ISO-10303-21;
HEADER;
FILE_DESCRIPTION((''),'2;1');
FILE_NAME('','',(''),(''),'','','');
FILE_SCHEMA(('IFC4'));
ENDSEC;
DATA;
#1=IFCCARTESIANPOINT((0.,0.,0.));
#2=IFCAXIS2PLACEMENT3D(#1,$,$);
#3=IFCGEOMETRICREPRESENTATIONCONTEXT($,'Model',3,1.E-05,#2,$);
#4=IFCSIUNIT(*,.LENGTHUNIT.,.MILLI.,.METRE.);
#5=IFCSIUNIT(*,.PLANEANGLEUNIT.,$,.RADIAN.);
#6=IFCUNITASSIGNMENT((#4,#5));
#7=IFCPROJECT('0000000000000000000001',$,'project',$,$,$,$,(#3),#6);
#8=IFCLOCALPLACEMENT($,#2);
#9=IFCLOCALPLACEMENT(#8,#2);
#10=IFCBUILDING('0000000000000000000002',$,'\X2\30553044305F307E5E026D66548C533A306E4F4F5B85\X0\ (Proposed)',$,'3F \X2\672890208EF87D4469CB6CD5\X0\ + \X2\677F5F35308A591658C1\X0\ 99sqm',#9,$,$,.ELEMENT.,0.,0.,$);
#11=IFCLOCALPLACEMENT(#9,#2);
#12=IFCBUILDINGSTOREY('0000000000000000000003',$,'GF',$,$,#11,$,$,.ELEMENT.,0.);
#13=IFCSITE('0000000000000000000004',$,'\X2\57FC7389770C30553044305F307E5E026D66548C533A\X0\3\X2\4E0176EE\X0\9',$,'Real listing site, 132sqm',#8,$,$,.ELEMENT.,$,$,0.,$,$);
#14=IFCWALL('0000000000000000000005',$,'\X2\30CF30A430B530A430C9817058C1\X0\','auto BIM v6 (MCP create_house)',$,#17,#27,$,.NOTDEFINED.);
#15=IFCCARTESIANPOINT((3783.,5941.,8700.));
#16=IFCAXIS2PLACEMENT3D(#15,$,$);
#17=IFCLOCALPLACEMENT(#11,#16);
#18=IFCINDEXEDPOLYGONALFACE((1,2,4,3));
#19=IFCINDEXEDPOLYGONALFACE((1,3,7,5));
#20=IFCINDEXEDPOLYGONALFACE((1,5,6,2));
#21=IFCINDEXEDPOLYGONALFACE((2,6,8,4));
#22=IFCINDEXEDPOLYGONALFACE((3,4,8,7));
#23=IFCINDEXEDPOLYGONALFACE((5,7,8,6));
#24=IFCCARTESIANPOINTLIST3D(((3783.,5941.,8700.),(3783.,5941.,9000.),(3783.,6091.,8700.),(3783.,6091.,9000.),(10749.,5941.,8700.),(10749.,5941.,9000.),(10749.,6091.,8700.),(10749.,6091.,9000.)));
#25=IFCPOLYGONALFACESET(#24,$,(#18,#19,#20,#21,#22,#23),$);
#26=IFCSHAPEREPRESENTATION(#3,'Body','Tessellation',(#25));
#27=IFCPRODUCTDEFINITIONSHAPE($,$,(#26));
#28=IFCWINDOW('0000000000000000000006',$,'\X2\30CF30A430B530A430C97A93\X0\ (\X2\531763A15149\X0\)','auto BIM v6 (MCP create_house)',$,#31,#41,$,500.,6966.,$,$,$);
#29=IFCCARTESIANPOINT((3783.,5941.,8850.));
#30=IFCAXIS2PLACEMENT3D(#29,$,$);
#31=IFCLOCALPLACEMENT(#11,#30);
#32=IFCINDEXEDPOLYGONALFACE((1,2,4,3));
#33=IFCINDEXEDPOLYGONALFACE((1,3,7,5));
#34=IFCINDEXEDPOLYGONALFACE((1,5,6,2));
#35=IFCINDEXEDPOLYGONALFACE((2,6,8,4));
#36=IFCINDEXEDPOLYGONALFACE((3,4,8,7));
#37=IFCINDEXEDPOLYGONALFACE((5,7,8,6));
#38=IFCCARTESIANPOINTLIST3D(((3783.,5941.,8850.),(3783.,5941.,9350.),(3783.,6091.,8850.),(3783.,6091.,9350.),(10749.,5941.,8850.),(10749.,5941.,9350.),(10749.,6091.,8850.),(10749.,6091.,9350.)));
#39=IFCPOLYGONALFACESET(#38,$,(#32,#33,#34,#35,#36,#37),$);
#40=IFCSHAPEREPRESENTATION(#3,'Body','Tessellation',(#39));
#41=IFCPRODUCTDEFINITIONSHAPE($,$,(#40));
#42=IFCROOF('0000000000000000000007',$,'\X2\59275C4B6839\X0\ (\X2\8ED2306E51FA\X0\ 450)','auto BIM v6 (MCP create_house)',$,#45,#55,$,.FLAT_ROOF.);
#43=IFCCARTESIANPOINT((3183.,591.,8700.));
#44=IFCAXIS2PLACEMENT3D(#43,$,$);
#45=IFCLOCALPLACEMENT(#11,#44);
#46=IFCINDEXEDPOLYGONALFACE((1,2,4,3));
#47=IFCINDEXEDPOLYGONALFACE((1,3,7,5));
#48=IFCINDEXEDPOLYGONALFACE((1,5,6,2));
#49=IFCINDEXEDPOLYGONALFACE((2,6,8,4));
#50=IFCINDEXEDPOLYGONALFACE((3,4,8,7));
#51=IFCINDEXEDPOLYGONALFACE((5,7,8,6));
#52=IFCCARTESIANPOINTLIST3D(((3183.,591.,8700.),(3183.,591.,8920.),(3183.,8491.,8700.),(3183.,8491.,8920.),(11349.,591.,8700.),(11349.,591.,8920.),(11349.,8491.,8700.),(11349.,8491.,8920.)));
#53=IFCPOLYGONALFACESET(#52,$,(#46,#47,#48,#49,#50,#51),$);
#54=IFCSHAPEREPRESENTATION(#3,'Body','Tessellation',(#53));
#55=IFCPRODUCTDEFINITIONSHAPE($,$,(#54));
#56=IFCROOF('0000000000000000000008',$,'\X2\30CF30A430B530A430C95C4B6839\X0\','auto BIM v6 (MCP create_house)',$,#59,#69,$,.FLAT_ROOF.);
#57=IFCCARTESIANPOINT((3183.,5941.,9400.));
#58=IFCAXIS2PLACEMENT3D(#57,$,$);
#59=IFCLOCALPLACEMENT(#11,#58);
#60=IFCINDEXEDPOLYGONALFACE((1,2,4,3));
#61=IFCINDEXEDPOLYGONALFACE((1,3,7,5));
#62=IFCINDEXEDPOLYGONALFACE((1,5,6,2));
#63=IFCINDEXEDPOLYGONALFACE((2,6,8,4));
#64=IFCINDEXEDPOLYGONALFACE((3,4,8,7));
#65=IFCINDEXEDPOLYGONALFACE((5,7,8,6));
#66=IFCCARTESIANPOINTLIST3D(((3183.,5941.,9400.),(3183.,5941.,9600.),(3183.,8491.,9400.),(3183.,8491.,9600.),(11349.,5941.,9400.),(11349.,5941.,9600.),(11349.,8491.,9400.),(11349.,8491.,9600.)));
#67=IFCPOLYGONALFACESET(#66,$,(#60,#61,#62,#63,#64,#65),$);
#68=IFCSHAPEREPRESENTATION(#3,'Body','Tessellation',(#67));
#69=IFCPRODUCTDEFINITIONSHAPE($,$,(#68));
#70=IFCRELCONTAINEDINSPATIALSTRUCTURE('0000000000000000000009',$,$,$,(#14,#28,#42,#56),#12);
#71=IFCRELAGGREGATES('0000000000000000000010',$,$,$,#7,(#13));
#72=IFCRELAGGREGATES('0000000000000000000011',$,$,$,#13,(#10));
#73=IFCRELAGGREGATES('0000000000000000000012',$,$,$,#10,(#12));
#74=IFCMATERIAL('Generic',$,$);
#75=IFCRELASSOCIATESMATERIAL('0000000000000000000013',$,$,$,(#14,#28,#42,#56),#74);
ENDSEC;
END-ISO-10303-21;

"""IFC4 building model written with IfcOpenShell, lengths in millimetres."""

from ifc_helpers import new_model, si_unit, frame, frame_2d, origin, place, context, project, spatial, rectangle, extrude, material, element, fill, save


model = new_model("IFC4")

# Units and contexts
model_context = context("Model", 3, precision=1e-05, world=origin())
ifc_project = project(units=[si_unit("LENGTHUNIT", "METRE", prefix="MILLI"), si_unit("PLANEANGLEUNIT", "RADIAN")], contexts=[model_context])

# Site, building, storey
site_placement = place(None, origin())
site = spatial("IfcSite", under=ifc_project, at=site_placement, Name="埼玉県さいたま市浦和区3丁目9", ObjectType="Real listing site, 132sqm", CompositionType="ELEMENT", RefElevation=0.0)
building_placement = place(site_placement, origin())
building = spatial("IfcBuilding", under=site, at=building_placement, Name="さいたま市浦和区の住宅 (Proposed)", ObjectType="3F 木造軸組構法 + 板張り外壁 99sqm", CompositionType="ELEMENT", ElevationOfRefHeight=0.0, ElevationOfTerrain=0.0)
storey_placement = place(building_placement, origin())
storey = spatial("IfcBuildingStorey", under=building, at=storey_placement, Name="GF", CompositionType="ELEMENT", Elevation=0.0)

# Shared definitions
ifc_material = material(Name="Generic")

# Wall, opening, window
wall_1_placement = place(storey_placement, frame((3783.0, 5941.0, 8700.0)))
wall_1 = element("IfcWall", 1, at=wall_1_placement, inside=storey, material=ifc_material, Name="ハイサイド腰壁", Description="auto BIM v6 (MCP create_house)", PredefinedType="NOTDEFINED", context=model_context, shape_type="SweptSolid", body=[
    extrude(rectangle(XDim=6966.0, YDim=150.0, at=frame_2d((3483.0, 75.0))), frame((3783.0, 5941.0, 8700.0)), (0.0, 0.0, 1.0), 700.0),
])
opening_1_placement = place(storey_placement, frame((3783.0, 5941.0, 8850.0)))
opening_1 = element("IfcOpeningElement", 2, at=opening_1_placement, cuts=wall_1, PredefinedType="NOTDEFINED", context=model_context, shape_type="SweptSolid", body=[
    extrude(rectangle(XDim=6966.0, YDim=150.0, at=frame_2d((3483.0, 75.0))), frame((3783.0, 5941.0, 8850.0)), (0.0, 0.0, 1.0), 500.0),
])
window_1_placement = place(storey_placement, frame((3783.0, 5941.0, 8850.0)))
window_1 = element("IfcWindow", 3, at=window_1_placement, inside=storey, material=ifc_material, Name="ハイサイド窓 (北採光)", Description="auto BIM v6 (MCP create_house)", OverallHeight=500.0, OverallWidth=6966.0, context=model_context, shape_type="SweptSolid", body=[
    extrude(rectangle(XDim=6966.0, YDim=150.0, at=frame_2d((3483.0, 75.0))), frame((3783.0, 5941.0, 8850.0)), (0.0, 0.0, 1.0), 500.0),
])
fill(opening_1, window_1)

# Roofs
roof_1_placement = place(storey_placement, frame((3183.0, 591.0, 8700.0)))
element("IfcRoof", 4, at=roof_1_placement, inside=storey, material=ifc_material, Name="大屋根 (軒の出 450)", Description="auto BIM v6 (MCP create_house)", PredefinedType="FLAT_ROOF", context=model_context, shape_type="SweptSolid", body=[
    extrude(rectangle(XDim=8166.0, YDim=7900.0, at=frame_2d((4083.0, 3950.0))), frame((3183.0, 591.0, 8700.0)), (0.0, 0.0, 1.0), 220.0),
])
roof_2_placement = place(storey_placement, frame((3183.0, 5941.0, 9400.0)))
element("IfcRoof", 5, at=roof_2_placement, inside=storey, material=ifc_material, Name="ハイサイド屋根", Description="auto BIM v6 (MCP create_house)", PredefinedType="FLAT_ROOF", context=model_context, shape_type="SweptSolid", body=[
    extrude(rectangle(XDim=8166.0, YDim=2550.0, at=frame_2d((4083.0, 1275.0))), frame((3183.0, 5941.0, 9400.0)), (0.0, 0.0, 1.0), 200.0),
])

save(model, "model.ifc")
